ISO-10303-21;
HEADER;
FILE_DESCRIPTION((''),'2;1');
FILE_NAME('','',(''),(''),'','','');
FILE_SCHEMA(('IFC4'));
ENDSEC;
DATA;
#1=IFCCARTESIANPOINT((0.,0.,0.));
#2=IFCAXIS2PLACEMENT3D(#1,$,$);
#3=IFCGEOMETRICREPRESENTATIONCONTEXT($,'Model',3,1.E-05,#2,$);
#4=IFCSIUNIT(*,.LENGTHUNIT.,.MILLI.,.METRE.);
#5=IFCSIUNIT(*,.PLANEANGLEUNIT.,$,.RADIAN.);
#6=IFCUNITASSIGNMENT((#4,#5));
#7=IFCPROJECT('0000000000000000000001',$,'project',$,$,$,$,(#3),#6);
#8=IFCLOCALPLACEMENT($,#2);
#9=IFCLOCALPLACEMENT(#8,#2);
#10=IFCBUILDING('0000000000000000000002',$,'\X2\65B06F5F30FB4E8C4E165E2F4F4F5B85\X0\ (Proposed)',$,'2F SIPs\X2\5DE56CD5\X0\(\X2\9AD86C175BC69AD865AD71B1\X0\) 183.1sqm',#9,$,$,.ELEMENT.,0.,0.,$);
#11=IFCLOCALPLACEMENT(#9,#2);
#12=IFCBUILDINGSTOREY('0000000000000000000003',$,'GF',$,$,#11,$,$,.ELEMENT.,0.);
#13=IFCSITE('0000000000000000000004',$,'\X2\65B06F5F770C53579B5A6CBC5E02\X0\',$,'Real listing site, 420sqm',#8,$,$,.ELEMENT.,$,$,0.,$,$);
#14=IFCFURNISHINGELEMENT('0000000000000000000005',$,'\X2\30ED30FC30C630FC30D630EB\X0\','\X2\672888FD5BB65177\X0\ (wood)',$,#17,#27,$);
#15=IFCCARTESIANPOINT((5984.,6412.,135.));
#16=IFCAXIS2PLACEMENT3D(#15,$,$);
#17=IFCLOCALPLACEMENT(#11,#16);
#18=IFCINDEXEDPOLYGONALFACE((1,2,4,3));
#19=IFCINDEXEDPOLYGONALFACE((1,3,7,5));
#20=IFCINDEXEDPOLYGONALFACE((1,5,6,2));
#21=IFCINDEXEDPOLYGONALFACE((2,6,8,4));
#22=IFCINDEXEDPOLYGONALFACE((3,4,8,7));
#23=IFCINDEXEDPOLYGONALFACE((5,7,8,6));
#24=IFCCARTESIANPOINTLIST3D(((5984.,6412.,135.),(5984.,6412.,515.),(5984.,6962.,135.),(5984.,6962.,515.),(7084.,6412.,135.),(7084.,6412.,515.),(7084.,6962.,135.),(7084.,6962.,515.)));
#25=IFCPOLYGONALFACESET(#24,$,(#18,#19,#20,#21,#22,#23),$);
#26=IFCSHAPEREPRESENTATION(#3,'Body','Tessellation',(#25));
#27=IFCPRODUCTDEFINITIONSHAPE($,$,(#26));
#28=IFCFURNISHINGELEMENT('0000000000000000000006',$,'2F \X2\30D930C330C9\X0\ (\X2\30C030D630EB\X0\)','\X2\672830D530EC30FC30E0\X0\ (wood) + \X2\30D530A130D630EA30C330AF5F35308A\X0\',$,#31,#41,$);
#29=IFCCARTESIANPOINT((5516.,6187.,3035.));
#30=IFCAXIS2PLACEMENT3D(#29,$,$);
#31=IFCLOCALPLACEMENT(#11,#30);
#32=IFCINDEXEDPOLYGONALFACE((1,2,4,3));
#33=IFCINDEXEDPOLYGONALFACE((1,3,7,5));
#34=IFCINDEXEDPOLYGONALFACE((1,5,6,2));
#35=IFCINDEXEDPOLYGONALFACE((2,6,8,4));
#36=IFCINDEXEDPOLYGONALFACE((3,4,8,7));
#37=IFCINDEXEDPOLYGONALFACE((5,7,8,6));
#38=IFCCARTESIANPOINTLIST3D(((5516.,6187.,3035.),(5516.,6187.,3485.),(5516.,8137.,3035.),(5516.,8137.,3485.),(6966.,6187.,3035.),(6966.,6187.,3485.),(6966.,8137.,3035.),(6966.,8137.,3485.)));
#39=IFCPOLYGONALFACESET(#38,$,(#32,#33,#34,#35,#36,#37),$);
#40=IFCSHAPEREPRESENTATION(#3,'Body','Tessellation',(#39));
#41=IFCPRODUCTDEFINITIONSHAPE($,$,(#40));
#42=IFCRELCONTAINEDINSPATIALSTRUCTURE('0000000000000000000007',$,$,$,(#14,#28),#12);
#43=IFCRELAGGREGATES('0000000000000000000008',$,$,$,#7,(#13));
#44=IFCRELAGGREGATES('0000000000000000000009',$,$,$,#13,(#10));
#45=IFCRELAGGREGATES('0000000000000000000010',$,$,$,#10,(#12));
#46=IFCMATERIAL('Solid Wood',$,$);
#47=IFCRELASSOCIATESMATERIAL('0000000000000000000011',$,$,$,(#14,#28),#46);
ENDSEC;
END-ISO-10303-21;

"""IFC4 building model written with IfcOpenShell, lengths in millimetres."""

from ifc_helpers import new_model, si_unit, frame, frame_2d, origin, place, context, project, spatial, rectangle, extrude, material, element, save


model = new_model("IFC4")

# Units and contexts
model_context = context("Model", 3, precision=1e-05, world=origin())
ifc_project = project(units=[si_unit("LENGTHUNIT", "METRE", prefix="MILLI"), si_unit("PLANEANGLEUNIT", "RADIAN")], contexts=[model_context])

# Site, building, storey
site_placement = place(None, origin())
site = spatial("IfcSite", under=ifc_project, at=site_placement, Name="新潟県南魚沼市", ObjectType="Real listing site, 420sqm", CompositionType="ELEMENT", RefElevation=0.0)
building_placement = place(site_placement, origin())
building = spatial("IfcBuilding", under=site, at=building_placement, Name="新潟・二世帯住宅 (Proposed)", ObjectType="2F SIPs工法(高気密高断熱) 183.1sqm", CompositionType="ELEMENT", ElevationOfRefHeight=0.0, ElevationOfTerrain=0.0)
storey_placement = place(building_placement, origin())
storey = spatial("IfcBuildingStorey", under=building, at=storey_placement, Name="GF", CompositionType="ELEMENT", Elevation=0.0)

# Shared definitions
ifc_material_1 = material(Name="Solid Wood")

# Furnishing elements
furnishing_1_placement = place(storey_placement, frame((5984.0, 6412.0, 135.0)))
element("IfcFurnishingElement", 1, at=furnishing_1_placement, inside=storey, material=ifc_material_1, Name="ローテーブル", Description="木製家具 (wood)", context=model_context, shape_type="SweptSolid", body=[
    extrude(rectangle(XDim=1100.0, YDim=550.0, at=frame_2d((550.0, 275.0))), frame((5984.0, 6412.0, 135.0)), (0.0, 0.0, 1.0), 380.0),
])
furnishing_2_placement = place(storey_placement, frame((5516.0, 6187.0, 3035.0)))
element("IfcFurnishingElement", 2, at=furnishing_2_placement, inside=storey, material=ifc_material_1, Name="2F ベッド (ダブル)", Description="木フレーム (wood) + ファブリック張り", context=model_context, shape_type="SweptSolid", body=[
    extrude(rectangle(XDim=1450.0, YDim=1950.0, at=frame_2d((725.0, 975.0))), frame((5516.0, 6187.0, 3035.0)), (0.0, 0.0, 1.0), 450.0),
])

save(model, "model.ifc")
